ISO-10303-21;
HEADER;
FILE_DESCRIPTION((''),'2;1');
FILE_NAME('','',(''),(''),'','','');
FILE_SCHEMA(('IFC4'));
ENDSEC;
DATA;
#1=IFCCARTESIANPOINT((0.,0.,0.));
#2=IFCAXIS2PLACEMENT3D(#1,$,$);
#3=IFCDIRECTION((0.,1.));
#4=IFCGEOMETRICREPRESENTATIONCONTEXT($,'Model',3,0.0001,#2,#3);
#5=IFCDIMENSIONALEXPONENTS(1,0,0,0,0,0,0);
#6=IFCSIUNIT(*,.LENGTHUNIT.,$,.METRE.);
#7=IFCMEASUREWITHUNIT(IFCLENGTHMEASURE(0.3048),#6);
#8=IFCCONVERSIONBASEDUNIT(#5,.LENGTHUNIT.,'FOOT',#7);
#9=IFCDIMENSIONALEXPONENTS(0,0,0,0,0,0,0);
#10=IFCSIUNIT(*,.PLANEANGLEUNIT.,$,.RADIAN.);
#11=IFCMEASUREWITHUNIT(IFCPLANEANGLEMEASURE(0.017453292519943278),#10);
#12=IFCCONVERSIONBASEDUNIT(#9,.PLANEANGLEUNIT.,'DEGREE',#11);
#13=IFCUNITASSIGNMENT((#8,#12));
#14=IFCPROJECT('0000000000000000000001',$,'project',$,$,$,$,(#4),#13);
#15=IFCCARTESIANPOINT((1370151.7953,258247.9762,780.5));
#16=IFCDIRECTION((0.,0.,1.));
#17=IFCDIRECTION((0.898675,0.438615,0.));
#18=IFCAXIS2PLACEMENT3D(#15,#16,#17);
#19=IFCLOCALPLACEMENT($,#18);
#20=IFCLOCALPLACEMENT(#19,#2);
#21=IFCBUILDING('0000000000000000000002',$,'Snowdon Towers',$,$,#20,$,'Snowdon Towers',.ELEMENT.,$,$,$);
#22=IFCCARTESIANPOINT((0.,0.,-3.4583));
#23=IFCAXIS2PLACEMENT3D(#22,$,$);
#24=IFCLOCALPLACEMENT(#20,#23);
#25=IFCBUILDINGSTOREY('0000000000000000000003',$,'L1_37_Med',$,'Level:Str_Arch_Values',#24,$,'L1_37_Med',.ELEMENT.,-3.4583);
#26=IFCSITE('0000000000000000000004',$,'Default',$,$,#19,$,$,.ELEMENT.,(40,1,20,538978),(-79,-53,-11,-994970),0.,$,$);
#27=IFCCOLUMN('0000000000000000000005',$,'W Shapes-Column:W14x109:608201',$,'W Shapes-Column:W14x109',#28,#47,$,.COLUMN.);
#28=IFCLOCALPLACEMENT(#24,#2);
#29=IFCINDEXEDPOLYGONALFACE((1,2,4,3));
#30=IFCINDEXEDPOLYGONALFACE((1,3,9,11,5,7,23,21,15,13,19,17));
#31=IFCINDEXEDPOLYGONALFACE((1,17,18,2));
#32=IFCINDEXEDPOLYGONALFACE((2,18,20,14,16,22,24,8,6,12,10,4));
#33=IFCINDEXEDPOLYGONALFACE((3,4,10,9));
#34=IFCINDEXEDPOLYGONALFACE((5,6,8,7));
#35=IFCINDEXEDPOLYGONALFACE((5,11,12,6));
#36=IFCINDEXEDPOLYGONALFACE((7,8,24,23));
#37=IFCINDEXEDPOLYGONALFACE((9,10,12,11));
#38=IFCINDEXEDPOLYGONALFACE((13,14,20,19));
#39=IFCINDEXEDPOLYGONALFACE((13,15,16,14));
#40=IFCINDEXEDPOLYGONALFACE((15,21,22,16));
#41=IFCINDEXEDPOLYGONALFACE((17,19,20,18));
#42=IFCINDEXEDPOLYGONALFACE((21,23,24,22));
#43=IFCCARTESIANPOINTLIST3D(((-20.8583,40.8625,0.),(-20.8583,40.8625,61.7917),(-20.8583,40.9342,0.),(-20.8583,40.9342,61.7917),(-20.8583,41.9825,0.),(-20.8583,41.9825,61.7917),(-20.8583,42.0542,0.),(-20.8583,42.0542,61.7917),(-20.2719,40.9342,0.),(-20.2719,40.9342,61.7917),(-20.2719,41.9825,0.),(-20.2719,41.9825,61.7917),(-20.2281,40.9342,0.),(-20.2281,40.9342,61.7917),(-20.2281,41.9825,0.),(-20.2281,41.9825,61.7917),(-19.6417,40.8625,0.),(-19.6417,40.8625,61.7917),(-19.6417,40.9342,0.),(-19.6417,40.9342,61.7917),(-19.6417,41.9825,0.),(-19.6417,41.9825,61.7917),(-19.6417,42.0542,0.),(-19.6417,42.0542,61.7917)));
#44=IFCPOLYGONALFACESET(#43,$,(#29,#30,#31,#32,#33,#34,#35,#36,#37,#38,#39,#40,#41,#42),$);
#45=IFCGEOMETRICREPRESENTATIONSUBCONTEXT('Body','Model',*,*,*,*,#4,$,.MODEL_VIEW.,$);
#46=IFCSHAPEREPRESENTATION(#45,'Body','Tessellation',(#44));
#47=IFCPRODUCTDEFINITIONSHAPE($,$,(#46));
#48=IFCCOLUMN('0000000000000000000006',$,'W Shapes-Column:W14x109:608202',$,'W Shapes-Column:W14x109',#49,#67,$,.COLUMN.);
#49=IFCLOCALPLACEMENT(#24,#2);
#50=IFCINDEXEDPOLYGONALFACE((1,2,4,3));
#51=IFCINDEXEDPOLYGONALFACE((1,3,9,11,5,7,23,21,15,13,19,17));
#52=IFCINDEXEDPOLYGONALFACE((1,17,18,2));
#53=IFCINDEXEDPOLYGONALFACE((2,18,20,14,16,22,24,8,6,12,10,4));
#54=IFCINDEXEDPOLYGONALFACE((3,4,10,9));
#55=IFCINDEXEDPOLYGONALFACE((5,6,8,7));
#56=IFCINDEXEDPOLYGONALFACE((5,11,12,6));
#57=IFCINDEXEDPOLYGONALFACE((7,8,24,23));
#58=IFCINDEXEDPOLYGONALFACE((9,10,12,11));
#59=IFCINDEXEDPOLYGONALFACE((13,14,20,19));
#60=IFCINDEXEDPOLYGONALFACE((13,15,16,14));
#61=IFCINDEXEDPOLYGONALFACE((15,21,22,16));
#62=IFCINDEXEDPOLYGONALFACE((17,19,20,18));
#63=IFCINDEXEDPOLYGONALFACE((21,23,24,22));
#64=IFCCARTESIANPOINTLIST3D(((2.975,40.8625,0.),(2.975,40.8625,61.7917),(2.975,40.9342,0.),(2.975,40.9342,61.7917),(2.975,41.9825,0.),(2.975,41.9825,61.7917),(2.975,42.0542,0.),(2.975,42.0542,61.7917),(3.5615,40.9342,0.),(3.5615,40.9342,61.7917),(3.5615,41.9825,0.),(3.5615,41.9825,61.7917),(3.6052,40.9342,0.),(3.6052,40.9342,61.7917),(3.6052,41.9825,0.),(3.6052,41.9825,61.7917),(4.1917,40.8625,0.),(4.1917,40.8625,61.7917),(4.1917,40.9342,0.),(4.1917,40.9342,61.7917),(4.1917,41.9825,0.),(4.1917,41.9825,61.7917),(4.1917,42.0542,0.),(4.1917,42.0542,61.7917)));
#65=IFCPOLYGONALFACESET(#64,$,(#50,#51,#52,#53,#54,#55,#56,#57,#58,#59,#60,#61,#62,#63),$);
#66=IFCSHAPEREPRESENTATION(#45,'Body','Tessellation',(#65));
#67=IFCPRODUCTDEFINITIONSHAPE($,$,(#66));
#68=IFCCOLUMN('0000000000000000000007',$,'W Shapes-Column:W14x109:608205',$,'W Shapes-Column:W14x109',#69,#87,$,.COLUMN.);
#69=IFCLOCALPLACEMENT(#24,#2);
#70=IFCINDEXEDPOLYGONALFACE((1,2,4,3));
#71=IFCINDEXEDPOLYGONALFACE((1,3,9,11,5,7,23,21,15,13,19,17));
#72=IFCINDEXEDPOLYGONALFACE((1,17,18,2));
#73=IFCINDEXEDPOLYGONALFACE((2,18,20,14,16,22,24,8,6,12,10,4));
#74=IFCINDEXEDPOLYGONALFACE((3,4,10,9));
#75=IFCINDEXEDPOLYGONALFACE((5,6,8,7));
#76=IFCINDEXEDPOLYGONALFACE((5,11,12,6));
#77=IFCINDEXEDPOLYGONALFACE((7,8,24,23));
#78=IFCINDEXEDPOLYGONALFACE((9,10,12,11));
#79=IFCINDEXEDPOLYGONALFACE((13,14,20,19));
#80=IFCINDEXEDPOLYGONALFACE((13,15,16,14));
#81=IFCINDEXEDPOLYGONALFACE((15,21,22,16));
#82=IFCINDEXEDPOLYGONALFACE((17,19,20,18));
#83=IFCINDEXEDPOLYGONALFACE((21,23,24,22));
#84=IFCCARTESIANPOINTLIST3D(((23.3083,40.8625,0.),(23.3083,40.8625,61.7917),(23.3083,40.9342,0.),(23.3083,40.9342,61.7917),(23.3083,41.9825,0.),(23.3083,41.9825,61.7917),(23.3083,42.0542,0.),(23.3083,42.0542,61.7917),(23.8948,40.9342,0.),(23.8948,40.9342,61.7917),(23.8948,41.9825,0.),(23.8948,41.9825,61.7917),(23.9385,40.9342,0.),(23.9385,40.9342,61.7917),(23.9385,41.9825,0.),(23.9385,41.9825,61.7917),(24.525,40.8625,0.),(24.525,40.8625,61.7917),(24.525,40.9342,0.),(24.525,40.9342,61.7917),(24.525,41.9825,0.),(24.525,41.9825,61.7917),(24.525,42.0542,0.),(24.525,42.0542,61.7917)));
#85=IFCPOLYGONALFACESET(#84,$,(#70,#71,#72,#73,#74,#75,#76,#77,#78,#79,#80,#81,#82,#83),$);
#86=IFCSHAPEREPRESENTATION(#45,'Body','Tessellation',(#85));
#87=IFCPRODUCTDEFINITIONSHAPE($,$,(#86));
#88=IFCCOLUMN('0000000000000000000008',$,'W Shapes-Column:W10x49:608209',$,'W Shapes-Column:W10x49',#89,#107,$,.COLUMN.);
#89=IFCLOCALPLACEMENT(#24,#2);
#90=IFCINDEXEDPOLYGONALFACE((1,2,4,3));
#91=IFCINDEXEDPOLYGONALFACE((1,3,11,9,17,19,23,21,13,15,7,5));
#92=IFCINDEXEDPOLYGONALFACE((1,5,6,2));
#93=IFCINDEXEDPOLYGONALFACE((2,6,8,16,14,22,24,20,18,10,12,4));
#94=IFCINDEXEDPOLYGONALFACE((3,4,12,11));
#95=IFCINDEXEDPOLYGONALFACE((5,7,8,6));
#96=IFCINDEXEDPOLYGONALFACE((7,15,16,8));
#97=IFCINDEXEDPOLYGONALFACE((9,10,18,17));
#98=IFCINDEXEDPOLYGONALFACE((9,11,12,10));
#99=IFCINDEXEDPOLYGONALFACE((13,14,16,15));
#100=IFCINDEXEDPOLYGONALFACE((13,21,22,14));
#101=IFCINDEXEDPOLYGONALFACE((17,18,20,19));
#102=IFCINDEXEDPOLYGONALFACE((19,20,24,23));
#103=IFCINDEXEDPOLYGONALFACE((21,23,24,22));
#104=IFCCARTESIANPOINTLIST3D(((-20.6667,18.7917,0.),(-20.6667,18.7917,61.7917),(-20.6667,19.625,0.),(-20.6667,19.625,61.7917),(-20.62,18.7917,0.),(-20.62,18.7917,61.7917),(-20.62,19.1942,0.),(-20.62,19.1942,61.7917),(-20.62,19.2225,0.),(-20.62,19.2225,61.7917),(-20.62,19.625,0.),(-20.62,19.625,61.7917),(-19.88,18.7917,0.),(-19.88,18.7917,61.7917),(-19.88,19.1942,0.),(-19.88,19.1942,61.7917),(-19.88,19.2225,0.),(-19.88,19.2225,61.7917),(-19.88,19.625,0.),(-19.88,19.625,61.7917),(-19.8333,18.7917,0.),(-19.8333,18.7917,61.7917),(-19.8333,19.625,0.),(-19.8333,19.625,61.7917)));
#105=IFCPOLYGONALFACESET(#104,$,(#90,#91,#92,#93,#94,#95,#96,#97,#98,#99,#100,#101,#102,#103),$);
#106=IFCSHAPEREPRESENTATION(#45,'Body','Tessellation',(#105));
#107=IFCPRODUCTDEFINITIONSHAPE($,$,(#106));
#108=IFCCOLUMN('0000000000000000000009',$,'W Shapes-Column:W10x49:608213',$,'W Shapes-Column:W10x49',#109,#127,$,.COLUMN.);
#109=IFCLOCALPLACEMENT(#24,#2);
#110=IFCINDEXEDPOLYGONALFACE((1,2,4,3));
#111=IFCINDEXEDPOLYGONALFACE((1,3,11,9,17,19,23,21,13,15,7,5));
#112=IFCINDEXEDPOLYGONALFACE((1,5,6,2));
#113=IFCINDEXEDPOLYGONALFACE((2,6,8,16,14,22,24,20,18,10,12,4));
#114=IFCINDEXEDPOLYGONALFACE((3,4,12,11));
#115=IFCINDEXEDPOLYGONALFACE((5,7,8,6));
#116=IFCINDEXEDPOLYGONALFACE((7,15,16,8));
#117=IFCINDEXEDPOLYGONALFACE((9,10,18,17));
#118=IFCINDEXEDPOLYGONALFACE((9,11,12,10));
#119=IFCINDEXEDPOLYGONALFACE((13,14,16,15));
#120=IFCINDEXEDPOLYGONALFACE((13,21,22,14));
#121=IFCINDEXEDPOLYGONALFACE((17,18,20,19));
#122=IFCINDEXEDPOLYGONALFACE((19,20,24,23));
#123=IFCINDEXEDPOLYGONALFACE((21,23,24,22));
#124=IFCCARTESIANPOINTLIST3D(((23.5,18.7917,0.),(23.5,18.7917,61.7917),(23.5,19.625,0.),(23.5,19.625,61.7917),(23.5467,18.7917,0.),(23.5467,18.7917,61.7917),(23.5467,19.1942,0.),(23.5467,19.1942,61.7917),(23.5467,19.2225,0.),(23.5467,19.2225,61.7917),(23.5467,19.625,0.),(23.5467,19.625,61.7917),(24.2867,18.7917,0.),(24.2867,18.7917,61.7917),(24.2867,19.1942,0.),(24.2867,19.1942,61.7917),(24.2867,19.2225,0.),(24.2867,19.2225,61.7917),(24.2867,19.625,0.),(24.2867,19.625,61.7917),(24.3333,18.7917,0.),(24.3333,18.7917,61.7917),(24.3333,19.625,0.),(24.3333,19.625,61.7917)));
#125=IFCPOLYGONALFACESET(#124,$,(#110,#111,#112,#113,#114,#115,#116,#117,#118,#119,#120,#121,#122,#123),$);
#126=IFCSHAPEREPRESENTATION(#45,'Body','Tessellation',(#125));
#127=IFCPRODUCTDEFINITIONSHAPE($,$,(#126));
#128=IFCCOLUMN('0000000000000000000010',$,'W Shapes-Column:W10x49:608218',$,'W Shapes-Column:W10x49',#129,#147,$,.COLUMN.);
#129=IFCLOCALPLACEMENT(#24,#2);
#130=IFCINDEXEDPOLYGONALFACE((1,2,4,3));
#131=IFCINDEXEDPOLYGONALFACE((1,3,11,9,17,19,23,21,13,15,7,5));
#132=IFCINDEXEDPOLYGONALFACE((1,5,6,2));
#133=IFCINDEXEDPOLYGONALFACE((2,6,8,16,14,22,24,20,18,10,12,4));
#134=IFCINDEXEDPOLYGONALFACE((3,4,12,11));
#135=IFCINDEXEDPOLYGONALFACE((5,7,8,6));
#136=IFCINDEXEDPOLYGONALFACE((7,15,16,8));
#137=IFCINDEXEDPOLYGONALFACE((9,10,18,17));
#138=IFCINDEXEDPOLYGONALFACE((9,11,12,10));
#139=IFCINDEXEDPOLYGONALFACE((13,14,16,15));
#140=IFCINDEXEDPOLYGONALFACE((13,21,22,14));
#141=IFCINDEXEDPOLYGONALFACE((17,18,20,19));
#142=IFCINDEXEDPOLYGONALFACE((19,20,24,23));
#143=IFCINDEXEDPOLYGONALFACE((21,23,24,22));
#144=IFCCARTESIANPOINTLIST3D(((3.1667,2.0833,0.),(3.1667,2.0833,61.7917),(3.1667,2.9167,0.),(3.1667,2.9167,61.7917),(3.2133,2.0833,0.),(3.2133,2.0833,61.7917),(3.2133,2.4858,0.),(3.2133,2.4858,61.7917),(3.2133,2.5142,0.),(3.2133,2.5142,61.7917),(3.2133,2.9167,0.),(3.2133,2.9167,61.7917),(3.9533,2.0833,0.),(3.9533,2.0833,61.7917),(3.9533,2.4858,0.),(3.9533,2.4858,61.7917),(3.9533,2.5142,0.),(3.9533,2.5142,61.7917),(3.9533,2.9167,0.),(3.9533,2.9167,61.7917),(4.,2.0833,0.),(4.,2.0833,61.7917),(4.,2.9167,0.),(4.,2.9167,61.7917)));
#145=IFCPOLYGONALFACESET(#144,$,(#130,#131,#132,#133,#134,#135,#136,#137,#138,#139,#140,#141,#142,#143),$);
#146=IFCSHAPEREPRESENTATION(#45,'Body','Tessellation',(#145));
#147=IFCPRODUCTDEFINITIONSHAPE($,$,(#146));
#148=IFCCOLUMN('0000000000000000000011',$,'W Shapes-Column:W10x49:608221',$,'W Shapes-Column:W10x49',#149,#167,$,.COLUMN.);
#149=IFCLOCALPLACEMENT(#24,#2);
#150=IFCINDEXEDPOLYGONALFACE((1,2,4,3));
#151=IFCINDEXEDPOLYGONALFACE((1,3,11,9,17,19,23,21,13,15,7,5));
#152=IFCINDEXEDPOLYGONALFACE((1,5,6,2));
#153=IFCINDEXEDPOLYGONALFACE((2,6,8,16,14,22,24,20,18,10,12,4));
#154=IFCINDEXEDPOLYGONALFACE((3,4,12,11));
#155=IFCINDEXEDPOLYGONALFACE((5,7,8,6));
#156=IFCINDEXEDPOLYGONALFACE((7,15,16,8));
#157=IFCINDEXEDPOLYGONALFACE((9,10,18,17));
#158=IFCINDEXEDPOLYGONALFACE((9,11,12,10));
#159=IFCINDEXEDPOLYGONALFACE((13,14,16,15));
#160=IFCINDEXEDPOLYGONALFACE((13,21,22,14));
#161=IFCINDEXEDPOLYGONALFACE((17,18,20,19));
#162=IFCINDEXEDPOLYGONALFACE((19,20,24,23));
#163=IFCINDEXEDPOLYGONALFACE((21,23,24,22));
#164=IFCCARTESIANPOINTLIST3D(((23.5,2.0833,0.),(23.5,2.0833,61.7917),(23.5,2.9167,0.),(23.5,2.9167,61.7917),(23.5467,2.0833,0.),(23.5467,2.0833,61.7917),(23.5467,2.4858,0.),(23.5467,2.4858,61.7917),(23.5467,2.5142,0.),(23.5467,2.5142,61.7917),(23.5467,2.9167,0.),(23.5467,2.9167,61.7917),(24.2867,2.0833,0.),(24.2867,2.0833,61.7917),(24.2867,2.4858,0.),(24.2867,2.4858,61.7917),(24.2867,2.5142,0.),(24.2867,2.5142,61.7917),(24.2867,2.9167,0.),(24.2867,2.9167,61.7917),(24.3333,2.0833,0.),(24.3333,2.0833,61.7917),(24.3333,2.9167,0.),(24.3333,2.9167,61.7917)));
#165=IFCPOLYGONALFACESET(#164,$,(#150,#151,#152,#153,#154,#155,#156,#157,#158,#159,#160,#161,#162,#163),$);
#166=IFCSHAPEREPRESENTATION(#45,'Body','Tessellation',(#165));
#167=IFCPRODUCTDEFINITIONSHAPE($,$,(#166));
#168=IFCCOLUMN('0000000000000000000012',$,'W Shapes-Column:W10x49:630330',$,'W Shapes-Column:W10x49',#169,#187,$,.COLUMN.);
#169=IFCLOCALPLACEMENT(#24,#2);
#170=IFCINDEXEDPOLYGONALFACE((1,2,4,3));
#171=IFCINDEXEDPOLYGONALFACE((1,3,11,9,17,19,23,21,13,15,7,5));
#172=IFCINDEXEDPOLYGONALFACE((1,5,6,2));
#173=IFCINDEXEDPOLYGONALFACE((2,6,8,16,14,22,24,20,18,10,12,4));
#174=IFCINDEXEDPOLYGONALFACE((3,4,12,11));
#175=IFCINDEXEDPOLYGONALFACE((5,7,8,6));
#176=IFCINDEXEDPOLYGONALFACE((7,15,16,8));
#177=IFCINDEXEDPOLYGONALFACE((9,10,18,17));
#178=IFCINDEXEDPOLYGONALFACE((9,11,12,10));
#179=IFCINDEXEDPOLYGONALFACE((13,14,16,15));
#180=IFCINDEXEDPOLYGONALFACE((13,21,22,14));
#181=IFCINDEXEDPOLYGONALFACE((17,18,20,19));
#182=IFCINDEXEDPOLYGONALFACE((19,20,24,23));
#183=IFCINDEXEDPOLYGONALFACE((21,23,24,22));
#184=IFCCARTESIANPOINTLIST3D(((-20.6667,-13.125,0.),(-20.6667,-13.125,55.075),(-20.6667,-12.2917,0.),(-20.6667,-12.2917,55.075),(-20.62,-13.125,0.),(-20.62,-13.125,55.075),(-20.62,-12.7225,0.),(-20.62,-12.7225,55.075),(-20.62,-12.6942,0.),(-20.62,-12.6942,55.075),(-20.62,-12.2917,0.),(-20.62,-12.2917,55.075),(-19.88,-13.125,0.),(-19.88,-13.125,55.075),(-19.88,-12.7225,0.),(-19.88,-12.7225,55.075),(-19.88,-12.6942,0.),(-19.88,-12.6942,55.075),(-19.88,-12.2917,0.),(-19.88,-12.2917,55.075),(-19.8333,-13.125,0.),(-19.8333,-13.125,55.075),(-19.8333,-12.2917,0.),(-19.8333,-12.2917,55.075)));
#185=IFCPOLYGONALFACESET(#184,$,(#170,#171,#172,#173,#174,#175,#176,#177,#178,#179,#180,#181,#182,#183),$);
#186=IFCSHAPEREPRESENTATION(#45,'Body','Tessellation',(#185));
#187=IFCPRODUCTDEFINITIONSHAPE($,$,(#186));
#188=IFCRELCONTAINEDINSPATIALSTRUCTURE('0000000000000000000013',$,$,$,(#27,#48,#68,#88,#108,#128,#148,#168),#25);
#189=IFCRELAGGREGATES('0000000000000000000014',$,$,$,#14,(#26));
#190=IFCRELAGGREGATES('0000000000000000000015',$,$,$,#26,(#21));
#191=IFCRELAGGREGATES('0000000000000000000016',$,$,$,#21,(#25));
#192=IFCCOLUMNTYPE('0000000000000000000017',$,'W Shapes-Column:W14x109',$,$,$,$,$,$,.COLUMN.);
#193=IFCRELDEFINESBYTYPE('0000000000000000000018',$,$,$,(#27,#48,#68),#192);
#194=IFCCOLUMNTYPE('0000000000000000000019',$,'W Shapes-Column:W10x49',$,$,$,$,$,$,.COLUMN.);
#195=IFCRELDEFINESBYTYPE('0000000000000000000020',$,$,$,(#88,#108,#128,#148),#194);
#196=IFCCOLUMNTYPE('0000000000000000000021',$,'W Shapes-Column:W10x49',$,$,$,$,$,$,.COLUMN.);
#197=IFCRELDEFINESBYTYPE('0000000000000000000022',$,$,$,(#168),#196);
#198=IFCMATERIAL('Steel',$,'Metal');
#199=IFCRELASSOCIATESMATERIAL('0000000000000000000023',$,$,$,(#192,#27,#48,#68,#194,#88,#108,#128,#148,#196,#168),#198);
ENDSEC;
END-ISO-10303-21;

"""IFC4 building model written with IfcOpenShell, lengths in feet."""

from ifc_helpers import new_model, entity, si_unit, converted_unit, direction, frame, origin, place, context, subcontext, project, spatial, indexed_curve, outline, extrude, source, transform, mapped, material, type_object, type_shapes, element, save


model = new_model("IFC4")

# Units and contexts
model_context = context("Model", 3, precision=0.0001, world=origin(), true_north=direction((0.0, 1.0)))
body_context = subcontext(model_context, "Body", "Model", "MODEL_VIEW")
ifc_project = project(units=[converted_unit("LENGTHUNIT", "FOOT", entity("IfcLengthMeasure", 0.3048), si_unit("LENGTHUNIT", "METRE"), dimensions=[1, 0, 0, 0, 0, 0, 0]), converted_unit("PLANEANGLEUNIT", "DEGREE", entity("IfcPlaneAngleMeasure", 0.017453292519943278), si_unit("PLANEANGLEUNIT", "RADIAN"), dimensions=[0, 0, 0, 0, 0, 0, 0])], contexts=[model_context])

# Site, building, storey
site_placement = place(None, frame((1370151.7953, 258247.9762, 780.5), z_axis=(0.0, 0.0, 1.0), x_axis=(0.898675, 0.438615, 0.0)))
site = spatial("IfcSite", under=ifc_project, at=site_placement, Name="Default", CompositionType="ELEMENT", RefLatitude=(40, 1, 20, 538978), RefLongitude=(-79, -53, -11, -994970), RefElevation=0.0)
building_placement = place(site_placement, origin())
building = spatial("IfcBuilding", under=site, at=building_placement, Name="Snowdon Towers", LongName="Snowdon Towers", CompositionType="ELEMENT")
storey_placement = place(building_placement, frame((0.0, 0.0, -3.4583)))
storey = spatial("IfcBuildingStorey", under=building, at=storey_placement, Name="L1_37_Med", ObjectType="Level:Str_Arch_Values", LongName="L1_37_Med", CompositionType="ELEMENT", Elevation=-3.4583)

# Columns
ifc_material_1 = material(Name="Steel", Category="Metal")
column_type_1 = type_object("IfcColumnType", Name="W Shapes-Column:W14x109", PredefinedType="COLUMN", material=ifc_material_1)
shared_shape_1 = source(origin(), body_context, "Body", "SweptSolid", [
    extrude(outline(indexed_curve([(-0.6083, -0.5958), (0.6083, -0.5958), (0.6083, -0.5242), (0.0219, -0.5242), (0.0219, 0.5242), (0.6083, 0.5242), (0.6083, 0.5958), (-0.6083, 0.5958), (-0.6083, 0.5242), (-0.0219, 0.5242), (-0.0219, -0.5242), (-0.6083, -0.5242), (-0.6083, -0.5958)], self_intersect=False)), frame((0.0, 0.0, -3.4583), z_axis=(0.0, 0.0, 1.0), x_axis=(-1.0, 0.0, 0.0)), (0.0, 0.0, 1.0), 61.7917),
])
type_shapes(column_type_1, [shared_shape_1])
for number, where, z_axis, x_axis, name in (
    (1, (-20.25, 41.4583, 3.4583), (0.0, 0.0, 1.0), (-1.0, 0.0, 0.0), "W Shapes-Column:W14x109:608201"),
    (2, (3.5833, 41.4583, 3.4583), (0.0, 0.0, 1.0), (-1.0, 0.0, 0.0), "W Shapes-Column:W14x109:608202"),
):
    element("IfcColumn", number, at=place(storey_placement, frame(where, z_axis=z_axis, x_axis=x_axis)), inside=storey, type_object=column_type_1, material=ifc_material_1, Name=name, ObjectType="W Shapes-Column:W14x109", PredefinedType="COLUMN", context=body_context, shape_type="MappedRepresentation", body=[
        mapped(shared_shape_1, transform((0.0, 0.0, 0.0), scale=1.0)),
    ])
column_1_placement = place(storey_placement, frame((23.9167, 41.4583, 3.4583)))
element("IfcColumn", 3, at=column_1_placement, inside=storey, type_object=column_type_1, material=ifc_material_1, Name="W Shapes-Column:W14x109:608205", ObjectType="W Shapes-Column:W14x109", PredefinedType="COLUMN", context=body_context, shape_type="MappedRepresentation", body=[
    mapped(shared_shape_1, transform((0.0, 0.0, 0.0), scale=1.0)),
])
column_type_2 = type_object("IfcColumnType", Name="W Shapes-Column:W10x49", PredefinedType="COLUMN", material=ifc_material_1)
shared_shape_2 = source(origin(), body_context, "Body", "SweptSolid", [
    extrude(outline(indexed_curve([(-0.4167, -0.4167), (0.4167, -0.4167), (0.4167, -0.37), (0.0142, -0.37), (0.0142, 0.37), (0.4167, 0.37), (0.4167, 0.4167), (-0.4167, 0.4167), (-0.4167, 0.37), (-0.0142, 0.37), (-0.0142, -0.37), (-0.4167, -0.37), (-0.4167, -0.4167)], self_intersect=False)), frame((0.0, 0.0, -3.4583), z_axis=(0.0, 0.0, 1.0), x_axis=(-1.0, 0.0, 0.0)), (0.0, 0.0, 1.0), 61.7917),
])
type_shapes(column_type_2, [shared_shape_2])
for number, where, z_axis, x_axis, name in (
    (4, (-20.25, 19.2083, 3.4583), (0.0, 0.0, 1.0), (0.0, 1.0, 0.0), "W Shapes-Column:W10x49:608209"),
    (5, (23.9167, 19.2083, 3.4583), (0.0, 0.0, 1.0), (0.0, 1.0, 0.0), "W Shapes-Column:W10x49:608213"),
    (6, (3.5833, 2.5, 3.4583), (0.0, 0.0, 1.0), (0.0, 1.0, 0.0), "W Shapes-Column:W10x49:608218"),
    (7, (23.9167, 2.5, 3.4583), (0.0, 0.0, 1.0), (0.0, 1.0, 0.0), "W Shapes-Column:W10x49:608221"),
):
    element("IfcColumn", number, at=place(storey_placement, frame(where, z_axis=z_axis, x_axis=x_axis)), inside=storey, type_object=column_type_2, material=ifc_material_1, Name=name, ObjectType="W Shapes-Column:W10x49", PredefinedType="COLUMN", context=body_context, shape_type="MappedRepresentation", body=[
        mapped(shared_shape_2, transform((0.0, 0.0, 0.0), scale=1.0)),
    ])
column_type_3 = type_object("IfcColumnType", Name="W Shapes-Column:W10x49", PredefinedType="COLUMN", material=ifc_material_1)
shared_shape_3 = source(origin(), body_context, "Body", "SweptSolid", [
    extrude(outline(indexed_curve([(-0.4167, -0.4167), (0.4167, -0.4167), (0.4167, -0.37), (0.0142, -0.37), (0.0142, 0.37), (0.4167, 0.37), (0.4167, 0.4167), (-0.4167, 0.4167), (-0.4167, 0.37), (-0.0142, 0.37), (-0.0142, -0.37), (-0.4167, -0.37), (-0.4167, -0.4167)], self_intersect=False)), frame((-20.25, -12.7083, -3.4583), z_axis=(0.0, 0.0, 1.0), x_axis=(0.0, -1.0, 0.0)), (0.0, 0.0, 1.0), 55.075),
])
type_shapes(column_type_3, [shared_shape_3])
column_2_placement = place(storey_placement, frame((0.0, 0.0, 3.4583)))
element("IfcColumn", 8, at=column_2_placement, inside=storey, type_object=column_type_3, material=ifc_material_1, Name="W Shapes-Column:W10x49:630330", ObjectType="W Shapes-Column:W10x49", PredefinedType="COLUMN", context=body_context, shape_type="MappedRepresentation", body=[
    mapped(shared_shape_3, transform((0.0, 0.0, 0.0), scale=1.0)),
])

save(model, "model.ifc")
